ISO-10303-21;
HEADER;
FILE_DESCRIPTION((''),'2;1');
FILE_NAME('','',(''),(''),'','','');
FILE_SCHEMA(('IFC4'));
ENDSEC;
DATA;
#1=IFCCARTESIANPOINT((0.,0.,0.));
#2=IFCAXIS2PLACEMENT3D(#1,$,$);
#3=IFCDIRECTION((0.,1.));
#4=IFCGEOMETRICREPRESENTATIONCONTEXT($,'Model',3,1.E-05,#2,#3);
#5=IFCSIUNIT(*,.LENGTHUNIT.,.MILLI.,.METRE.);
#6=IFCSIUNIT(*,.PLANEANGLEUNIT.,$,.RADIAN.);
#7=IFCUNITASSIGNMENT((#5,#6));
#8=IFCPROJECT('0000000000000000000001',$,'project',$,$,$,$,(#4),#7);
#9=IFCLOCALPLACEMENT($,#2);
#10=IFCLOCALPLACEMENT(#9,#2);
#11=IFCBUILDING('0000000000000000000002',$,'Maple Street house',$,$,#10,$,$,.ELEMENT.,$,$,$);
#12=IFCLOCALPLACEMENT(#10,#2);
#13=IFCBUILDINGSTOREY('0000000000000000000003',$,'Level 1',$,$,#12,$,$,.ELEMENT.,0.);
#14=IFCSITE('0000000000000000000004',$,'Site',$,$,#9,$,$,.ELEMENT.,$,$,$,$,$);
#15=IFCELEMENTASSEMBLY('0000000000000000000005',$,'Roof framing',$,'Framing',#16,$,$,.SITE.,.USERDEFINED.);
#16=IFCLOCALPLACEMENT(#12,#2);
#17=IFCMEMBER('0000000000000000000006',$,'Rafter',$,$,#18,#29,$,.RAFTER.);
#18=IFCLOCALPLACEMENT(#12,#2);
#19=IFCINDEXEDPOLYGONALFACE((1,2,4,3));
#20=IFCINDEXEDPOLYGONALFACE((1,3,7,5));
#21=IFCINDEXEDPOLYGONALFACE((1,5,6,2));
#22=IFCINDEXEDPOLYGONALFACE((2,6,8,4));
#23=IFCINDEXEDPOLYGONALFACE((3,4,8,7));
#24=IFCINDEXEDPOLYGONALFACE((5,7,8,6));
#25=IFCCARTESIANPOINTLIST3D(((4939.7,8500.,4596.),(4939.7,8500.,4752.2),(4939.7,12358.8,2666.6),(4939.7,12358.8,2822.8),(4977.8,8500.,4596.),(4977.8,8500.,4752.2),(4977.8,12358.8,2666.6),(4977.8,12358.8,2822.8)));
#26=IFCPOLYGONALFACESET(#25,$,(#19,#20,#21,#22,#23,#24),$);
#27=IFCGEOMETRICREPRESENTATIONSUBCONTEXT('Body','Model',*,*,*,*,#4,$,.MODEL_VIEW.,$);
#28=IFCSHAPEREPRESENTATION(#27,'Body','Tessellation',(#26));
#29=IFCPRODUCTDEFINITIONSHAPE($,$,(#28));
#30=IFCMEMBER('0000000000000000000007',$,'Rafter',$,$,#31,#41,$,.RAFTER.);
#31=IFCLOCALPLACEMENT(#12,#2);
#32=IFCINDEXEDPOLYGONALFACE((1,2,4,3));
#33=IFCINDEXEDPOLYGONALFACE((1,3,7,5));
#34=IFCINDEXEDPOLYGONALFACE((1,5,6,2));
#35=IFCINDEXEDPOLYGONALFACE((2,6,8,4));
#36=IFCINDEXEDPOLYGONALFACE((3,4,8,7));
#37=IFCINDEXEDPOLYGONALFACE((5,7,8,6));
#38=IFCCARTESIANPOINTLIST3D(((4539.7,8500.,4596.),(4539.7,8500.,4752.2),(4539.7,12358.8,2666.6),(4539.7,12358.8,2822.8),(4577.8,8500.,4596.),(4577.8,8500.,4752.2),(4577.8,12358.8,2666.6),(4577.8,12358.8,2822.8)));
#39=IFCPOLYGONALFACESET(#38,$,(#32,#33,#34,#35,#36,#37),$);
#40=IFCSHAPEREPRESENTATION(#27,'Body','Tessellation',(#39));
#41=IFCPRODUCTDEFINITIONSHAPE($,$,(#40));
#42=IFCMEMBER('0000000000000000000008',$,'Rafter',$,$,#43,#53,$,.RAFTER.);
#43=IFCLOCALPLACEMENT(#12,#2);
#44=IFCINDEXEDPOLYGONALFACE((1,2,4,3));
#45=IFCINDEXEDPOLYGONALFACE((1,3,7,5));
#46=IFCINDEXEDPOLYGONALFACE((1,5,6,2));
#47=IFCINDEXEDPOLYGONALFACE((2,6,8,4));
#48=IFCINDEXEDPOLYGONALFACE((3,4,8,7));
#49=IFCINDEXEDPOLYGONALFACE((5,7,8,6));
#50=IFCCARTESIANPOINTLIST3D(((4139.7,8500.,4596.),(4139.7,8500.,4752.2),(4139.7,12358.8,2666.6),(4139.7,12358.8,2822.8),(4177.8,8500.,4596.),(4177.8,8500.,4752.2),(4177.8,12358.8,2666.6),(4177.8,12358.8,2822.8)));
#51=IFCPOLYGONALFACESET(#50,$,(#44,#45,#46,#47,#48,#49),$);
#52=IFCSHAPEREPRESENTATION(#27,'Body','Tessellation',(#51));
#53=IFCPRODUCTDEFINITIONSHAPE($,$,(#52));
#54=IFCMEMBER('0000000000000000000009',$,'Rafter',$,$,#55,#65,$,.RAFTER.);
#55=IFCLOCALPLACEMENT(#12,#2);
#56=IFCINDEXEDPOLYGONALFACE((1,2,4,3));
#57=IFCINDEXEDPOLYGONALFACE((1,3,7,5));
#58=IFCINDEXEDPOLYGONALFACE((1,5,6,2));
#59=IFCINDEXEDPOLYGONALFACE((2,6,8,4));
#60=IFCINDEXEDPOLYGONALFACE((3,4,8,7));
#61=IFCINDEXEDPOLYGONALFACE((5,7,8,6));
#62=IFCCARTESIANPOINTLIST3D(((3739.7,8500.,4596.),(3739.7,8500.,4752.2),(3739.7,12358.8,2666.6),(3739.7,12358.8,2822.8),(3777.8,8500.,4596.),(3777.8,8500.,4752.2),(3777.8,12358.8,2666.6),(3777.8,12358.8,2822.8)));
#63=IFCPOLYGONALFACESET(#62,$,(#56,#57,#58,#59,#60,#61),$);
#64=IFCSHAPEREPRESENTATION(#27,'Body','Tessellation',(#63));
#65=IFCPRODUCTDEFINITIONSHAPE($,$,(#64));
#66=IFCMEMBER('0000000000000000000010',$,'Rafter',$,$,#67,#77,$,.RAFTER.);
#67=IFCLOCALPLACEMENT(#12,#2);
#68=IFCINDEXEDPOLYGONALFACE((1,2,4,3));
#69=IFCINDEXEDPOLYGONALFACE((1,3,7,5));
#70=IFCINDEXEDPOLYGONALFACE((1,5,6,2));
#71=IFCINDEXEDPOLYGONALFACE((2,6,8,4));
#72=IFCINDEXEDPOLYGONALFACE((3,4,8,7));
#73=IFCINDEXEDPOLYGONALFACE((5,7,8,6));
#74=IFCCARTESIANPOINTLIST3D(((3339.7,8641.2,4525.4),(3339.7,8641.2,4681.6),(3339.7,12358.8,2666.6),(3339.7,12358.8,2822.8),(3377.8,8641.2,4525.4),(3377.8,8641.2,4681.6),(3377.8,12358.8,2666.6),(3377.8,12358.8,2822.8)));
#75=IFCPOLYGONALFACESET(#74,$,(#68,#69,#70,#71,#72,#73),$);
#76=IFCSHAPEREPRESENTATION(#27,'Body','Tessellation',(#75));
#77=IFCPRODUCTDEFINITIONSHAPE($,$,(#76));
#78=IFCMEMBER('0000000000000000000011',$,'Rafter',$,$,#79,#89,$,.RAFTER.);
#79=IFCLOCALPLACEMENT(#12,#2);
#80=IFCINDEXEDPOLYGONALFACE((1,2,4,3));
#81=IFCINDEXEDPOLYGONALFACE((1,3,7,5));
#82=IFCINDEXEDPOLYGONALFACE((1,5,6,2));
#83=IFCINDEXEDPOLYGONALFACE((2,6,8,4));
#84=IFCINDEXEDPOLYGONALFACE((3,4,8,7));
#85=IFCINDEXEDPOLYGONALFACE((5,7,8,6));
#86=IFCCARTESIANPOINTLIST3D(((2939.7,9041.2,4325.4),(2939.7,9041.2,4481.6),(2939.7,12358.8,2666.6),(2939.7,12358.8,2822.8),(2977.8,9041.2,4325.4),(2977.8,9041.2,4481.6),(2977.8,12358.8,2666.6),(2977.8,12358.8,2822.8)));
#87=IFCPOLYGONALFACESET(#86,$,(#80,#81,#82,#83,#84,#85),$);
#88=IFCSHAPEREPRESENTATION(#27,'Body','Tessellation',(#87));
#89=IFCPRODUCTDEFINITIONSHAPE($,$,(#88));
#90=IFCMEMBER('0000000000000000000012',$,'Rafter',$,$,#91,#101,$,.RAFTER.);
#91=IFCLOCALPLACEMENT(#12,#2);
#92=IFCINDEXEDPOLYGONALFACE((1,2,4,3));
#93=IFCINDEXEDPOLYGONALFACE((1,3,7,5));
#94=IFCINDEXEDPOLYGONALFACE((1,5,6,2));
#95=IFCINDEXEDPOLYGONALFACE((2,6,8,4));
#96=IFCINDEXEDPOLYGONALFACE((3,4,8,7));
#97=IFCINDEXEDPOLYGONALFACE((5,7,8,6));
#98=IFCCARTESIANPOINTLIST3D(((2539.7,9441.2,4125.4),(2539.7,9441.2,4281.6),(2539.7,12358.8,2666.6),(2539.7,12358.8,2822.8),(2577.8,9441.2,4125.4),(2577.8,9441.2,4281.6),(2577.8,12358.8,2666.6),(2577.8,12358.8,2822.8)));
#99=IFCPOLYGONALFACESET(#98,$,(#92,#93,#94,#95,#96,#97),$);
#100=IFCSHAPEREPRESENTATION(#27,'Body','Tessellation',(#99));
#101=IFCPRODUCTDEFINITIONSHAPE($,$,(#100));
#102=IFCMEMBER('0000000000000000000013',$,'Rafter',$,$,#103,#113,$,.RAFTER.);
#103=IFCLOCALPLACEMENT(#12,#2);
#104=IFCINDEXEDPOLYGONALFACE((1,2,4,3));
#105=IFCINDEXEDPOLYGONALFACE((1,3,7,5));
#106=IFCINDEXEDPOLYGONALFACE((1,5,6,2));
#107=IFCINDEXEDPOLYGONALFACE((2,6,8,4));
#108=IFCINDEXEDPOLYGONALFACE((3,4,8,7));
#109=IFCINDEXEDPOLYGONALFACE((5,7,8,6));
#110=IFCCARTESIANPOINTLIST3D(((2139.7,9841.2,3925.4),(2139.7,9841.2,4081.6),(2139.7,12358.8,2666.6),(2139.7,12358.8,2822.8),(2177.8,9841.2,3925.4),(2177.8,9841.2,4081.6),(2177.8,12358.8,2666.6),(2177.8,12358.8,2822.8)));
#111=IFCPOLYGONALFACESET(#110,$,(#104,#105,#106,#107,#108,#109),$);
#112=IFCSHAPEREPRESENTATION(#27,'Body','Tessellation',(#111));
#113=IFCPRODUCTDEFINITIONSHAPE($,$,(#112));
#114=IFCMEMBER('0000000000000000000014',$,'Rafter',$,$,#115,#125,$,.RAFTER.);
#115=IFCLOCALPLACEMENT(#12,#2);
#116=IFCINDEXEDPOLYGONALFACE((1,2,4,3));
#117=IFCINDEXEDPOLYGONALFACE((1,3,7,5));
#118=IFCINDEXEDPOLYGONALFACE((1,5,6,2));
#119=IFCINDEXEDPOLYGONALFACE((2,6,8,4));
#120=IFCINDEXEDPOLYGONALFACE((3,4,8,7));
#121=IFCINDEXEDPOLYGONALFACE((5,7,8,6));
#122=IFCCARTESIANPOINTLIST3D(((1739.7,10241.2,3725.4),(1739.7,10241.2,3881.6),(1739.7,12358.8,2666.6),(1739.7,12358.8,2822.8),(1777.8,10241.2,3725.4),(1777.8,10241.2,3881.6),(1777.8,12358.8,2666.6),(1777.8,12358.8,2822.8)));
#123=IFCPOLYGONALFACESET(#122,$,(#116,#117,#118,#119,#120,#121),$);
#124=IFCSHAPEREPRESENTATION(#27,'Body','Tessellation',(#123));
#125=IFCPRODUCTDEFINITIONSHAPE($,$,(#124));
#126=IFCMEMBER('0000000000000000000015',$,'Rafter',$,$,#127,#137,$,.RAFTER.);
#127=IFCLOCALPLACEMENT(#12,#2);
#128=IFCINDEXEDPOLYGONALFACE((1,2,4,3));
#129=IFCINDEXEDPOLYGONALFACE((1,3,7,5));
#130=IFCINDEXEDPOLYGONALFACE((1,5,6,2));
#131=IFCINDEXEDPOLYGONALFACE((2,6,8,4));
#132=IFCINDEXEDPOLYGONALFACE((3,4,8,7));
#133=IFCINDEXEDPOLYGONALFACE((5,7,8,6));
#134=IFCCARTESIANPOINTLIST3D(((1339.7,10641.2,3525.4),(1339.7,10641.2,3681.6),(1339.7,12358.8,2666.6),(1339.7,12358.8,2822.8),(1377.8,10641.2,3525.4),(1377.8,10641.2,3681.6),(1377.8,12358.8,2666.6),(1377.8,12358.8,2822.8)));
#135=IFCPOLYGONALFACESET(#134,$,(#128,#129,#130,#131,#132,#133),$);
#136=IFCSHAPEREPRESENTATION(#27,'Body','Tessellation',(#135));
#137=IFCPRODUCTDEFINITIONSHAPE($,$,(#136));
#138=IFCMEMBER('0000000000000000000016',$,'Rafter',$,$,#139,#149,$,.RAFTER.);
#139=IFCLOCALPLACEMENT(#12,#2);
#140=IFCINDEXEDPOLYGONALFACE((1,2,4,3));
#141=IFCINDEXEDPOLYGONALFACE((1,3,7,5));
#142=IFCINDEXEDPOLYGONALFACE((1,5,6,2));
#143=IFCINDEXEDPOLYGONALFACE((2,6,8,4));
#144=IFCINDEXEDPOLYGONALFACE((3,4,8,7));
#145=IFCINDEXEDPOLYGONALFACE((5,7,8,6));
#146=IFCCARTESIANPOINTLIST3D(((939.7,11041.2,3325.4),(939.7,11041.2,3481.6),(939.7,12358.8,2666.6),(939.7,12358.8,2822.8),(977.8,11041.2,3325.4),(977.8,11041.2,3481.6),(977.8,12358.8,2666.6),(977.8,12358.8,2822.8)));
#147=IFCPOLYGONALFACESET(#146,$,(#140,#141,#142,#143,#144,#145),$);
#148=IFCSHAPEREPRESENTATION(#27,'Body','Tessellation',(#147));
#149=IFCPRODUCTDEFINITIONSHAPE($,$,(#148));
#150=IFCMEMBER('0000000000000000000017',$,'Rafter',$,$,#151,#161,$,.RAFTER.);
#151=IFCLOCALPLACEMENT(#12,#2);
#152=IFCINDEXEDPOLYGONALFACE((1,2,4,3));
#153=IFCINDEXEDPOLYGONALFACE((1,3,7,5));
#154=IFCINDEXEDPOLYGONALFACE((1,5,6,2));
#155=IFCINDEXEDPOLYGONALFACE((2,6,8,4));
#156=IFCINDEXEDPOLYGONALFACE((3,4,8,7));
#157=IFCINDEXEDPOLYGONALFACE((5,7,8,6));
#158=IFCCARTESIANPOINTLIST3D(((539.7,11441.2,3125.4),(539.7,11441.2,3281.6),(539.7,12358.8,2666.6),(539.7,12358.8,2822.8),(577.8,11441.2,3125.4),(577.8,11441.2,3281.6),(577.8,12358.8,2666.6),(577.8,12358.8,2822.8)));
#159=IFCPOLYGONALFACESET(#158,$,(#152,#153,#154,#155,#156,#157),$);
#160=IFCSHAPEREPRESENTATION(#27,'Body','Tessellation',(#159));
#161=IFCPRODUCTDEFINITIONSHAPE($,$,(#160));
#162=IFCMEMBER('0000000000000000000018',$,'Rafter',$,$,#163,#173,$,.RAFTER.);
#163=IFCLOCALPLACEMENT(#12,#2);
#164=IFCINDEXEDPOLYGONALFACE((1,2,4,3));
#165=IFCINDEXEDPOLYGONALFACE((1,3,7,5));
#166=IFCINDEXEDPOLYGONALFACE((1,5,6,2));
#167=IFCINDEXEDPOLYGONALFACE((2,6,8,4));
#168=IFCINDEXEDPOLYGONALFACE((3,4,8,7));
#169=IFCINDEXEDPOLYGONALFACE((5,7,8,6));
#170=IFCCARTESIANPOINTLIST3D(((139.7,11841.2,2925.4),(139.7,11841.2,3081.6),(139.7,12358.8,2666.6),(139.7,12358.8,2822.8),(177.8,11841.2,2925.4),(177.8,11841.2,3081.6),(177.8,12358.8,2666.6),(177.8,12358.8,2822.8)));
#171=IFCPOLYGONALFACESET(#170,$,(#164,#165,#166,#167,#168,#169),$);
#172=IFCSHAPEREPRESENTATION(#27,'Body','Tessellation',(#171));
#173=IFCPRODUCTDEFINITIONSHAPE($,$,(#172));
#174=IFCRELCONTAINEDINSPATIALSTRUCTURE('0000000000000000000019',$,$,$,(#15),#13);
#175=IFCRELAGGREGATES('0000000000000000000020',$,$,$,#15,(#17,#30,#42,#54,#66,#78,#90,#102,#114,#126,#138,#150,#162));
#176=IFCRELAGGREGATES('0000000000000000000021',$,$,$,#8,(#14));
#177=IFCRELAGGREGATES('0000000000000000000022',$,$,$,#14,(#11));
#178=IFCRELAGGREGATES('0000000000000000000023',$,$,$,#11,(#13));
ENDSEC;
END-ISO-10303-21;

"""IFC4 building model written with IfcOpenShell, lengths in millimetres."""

from ifc_helpers import new_model, si_unit, direction, frame, origin, origin_with_axes, place, context, subcontext, project, spatial, polyline, outline, extrude, element, aggregate, save


model = new_model("IFC4")

# Units and contexts
model_context = context("Model", 3, precision=1e-05, world=origin(), true_north=direction((0.0, 1.0)))
body_context = subcontext(model_context, "Body", "Model", "MODEL_VIEW")
ifc_project = project(units=[si_unit("LENGTHUNIT", "METRE", prefix="MILLI"), si_unit("PLANEANGLEUNIT", "RADIAN")], contexts=[model_context])

# Site, building, storey
site_placement = place(None, origin())
site = spatial("IfcSite", under=ifc_project, at=site_placement, Name="Site", CompositionType="ELEMENT")
building_placement = place(site_placement, origin())
building = spatial("IfcBuilding", under=site, at=building_placement, Name="Maple Street house", CompositionType="ELEMENT")
storey_placement = place(building_placement, origin())
storey = spatial("IfcBuildingStorey", under=building, at=storey_placement, Name="Level 1", CompositionType="ELEMENT", Elevation=0.0)

# Element assembly, members
assembly_placement = place(storey_placement, origin_with_axes())
assembly = element("IfcElementAssembly", 1, at=assembly_placement, inside=storey, Name="Roof framing", ObjectType="Framing", AssemblyPlace="SITE", PredefinedType="USERDEFINED")
member_1_placement = place(storey_placement, origin_with_axes())
member_1 = element("IfcMember", 2, at=member_1_placement, Name="Rafter", PredefinedType="RAFTER", context=body_context, shape_type="SweptSolid", body=[
    extrude(outline(polyline([(0.0, 0.0), (38.1, 0.0), (38.1, 156.2), (0.0, 156.2), (0.0, 0.0)])), frame((4939.7, 12358.8, 2666.7), z_axis=(0.0, -1.0, 0.0), x_axis=(1.0, 0.0, 0.0)), (0.0, 0.447214, 0.894427), 4314.2),
])
member_2_placement = place(storey_placement, origin_with_axes())
member_2 = element("IfcMember", 3, at=member_2_placement, Name="Rafter", PredefinedType="RAFTER", context=body_context, shape_type="SweptSolid", body=[
    extrude(outline(polyline([(0.0, 0.0), (38.1, 0.0), (38.1, 156.2), (0.0, 156.2), (0.0, 0.0)])), frame((4539.7, 12358.8, 2666.7), z_axis=(0.0, -1.0, 0.0), x_axis=(1.0, 0.0, 0.0)), (0.0, 0.447214, 0.894427), 4314.2),
])
member_3_placement = place(storey_placement, origin_with_axes())
member_3 = element("IfcMember", 4, at=member_3_placement, Name="Rafter", PredefinedType="RAFTER", context=body_context, shape_type="SweptSolid", body=[
    extrude(outline(polyline([(0.0, 0.0), (38.1, 0.0), (38.1, 156.2), (0.0, 156.2), (0.0, 0.0)])), frame((4139.7, 12358.8, 2666.7), z_axis=(0.0, -1.0, 0.0), x_axis=(1.0, 0.0, 0.0)), (0.0, 0.447214, 0.894427), 4314.2),
])
member_4_placement = place(storey_placement, origin_with_axes())
member_4 = element("IfcMember", 5, at=member_4_placement, Name="Rafter", PredefinedType="RAFTER", context=body_context, shape_type="SweptSolid", body=[
    extrude(outline(polyline([(0.0, 0.0), (38.1, 0.0), (38.1, 156.2), (0.0, 156.2), (0.0, 0.0)])), frame((3739.7, 12358.8, 2666.7), z_axis=(0.0, -1.0, 0.0), x_axis=(1.0, 0.0, 0.0)), (0.0, 0.447214, 0.894427), 4314.2),
])
member_5_placement = place(storey_placement, origin_with_axes())
member_5 = element("IfcMember", 6, at=member_5_placement, Name="Rafter", PredefinedType="RAFTER", context=body_context, shape_type="SweptSolid", body=[
    extrude(outline(polyline([(0.0, 0.0), (38.1, 0.0), (38.1, 156.2), (0.0, 156.2), (0.0, 0.0)])), frame((3339.7, 12358.8, 2666.7), z_axis=(0.0, -1.0, 0.0), x_axis=(1.0, 0.0, 0.0)), (0.0, 0.447214, 0.894427), 4156.3),
])
member_6_placement = place(storey_placement, origin_with_axes())
member_6 = element("IfcMember", 7, at=member_6_placement, Name="Rafter", PredefinedType="RAFTER", context=body_context, shape_type="SweptSolid", body=[
    extrude(outline(polyline([(0.0, 0.0), (38.1, 0.0), (38.1, 156.2), (0.0, 156.2), (0.0, 0.0)])), frame((2939.7, 12358.8, 2666.7), z_axis=(0.0, -1.0, 0.0), x_axis=(1.0, 0.0, 0.0)), (0.0, 0.447214, 0.894427), 3709.1),
])
member_7_placement = place(storey_placement, origin_with_axes())
member_7 = element("IfcMember", 8, at=member_7_placement, Name="Rafter", PredefinedType="RAFTER", context=body_context, shape_type="SweptSolid", body=[
    extrude(outline(polyline([(0.0, 0.0), (38.1, 0.0), (38.1, 156.2), (0.0, 156.2), (0.0, 0.0)])), frame((2539.7, 12358.8, 2666.7), z_axis=(0.0, -1.0, 0.0), x_axis=(1.0, 0.0, 0.0)), (0.0, 0.447214, 0.894427), 3261.9),
])
member_8_placement = place(storey_placement, origin_with_axes())
member_8 = element("IfcMember", 9, at=member_8_placement, Name="Rafter", PredefinedType="RAFTER", context=body_context, shape_type="SweptSolid", body=[
    extrude(outline(polyline([(0.0, 0.0), (38.1, 0.0), (38.1, 156.2), (0.0, 156.2), (0.0, 0.0)])), frame((2139.7, 12358.8, 2666.7), z_axis=(0.0, -1.0, 0.0), x_axis=(1.0, 0.0, 0.0)), (0.0, 0.447214, 0.894427), 2814.7),
])
member_9_placement = place(storey_placement, origin_with_axes())
member_9 = element("IfcMember", 10, at=member_9_placement, Name="Rafter", PredefinedType="RAFTER", context=body_context, shape_type="SweptSolid", body=[
    extrude(outline(polyline([(0.0, 0.0), (38.1, 0.0), (38.1, 156.2), (0.0, 156.2), (0.0, 0.0)])), frame((1739.7, 12358.8, 2666.7), z_axis=(0.0, -1.0, 0.0), x_axis=(1.0, 0.0, 0.0)), (0.0, 0.447214, 0.894427), 2367.5),
])
member_10_placement = place(storey_placement, origin_with_axes())
member_10 = element("IfcMember", 11, at=member_10_placement, Name="Rafter", PredefinedType="RAFTER", context=body_context, shape_type="SweptSolid", body=[
    extrude(outline(polyline([(0.0, 0.0), (38.1, 0.0), (38.1, 156.2), (0.0, 156.2), (0.0, 0.0)])), frame((1339.7, 12358.8, 2666.7), z_axis=(0.0, -1.0, 0.0), x_axis=(1.0, 0.0, 0.0)), (0.0, 0.447214, 0.894427), 1920.3),
])
member_11_placement = place(storey_placement, origin_with_axes())
member_11 = element("IfcMember", 12, at=member_11_placement, Name="Rafter", PredefinedType="RAFTER", context=body_context, shape_type="SweptSolid", body=[
    extrude(outline(polyline([(0.0, 0.0), (38.1, 0.0), (38.1, 156.2), (0.0, 156.2), (0.0, 0.0)])), frame((939.7, 12358.8, 2666.7), z_axis=(0.0, -1.0, 0.0), x_axis=(1.0, 0.0, 0.0)), (0.0, 0.447214, 0.894427), 1473.1),
])
member_12_placement = place(storey_placement, origin_with_axes())
member_12 = element("IfcMember", 13, at=member_12_placement, Name="Rafter", PredefinedType="RAFTER", context=body_context, shape_type="SweptSolid", body=[
    extrude(outline(polyline([(0.0, 0.0), (38.1, 0.0), (38.1, 156.2), (0.0, 156.2), (0.0, 0.0)])), frame((539.7, 12358.8, 2666.7), z_axis=(0.0, -1.0, 0.0), x_axis=(1.0, 0.0, 0.0)), (0.0, 0.447214, 0.894427), 1025.9),
])
member_13_placement = place(storey_placement, origin_with_axes())
member_13 = element("IfcMember", 14, at=member_13_placement, Name="Rafter", PredefinedType="RAFTER", context=body_context, shape_type="SweptSolid", body=[
    extrude(outline(polyline([(0.0, 0.0), (38.1, 0.0), (38.1, 156.2), (0.0, 156.2), (0.0, 0.0)])), frame((139.7, 12358.8, 2666.7), z_axis=(0.0, -1.0, 0.0), x_axis=(1.0, 0.0, 0.0)), (0.0, 0.447214, 0.894427), 578.6),
])
aggregate(assembly, [member_1, member_2, member_3, member_4, member_5, member_6, member_7, member_8, member_9, member_10, member_11, member_12, member_13])

save(model, "model.ifc")
